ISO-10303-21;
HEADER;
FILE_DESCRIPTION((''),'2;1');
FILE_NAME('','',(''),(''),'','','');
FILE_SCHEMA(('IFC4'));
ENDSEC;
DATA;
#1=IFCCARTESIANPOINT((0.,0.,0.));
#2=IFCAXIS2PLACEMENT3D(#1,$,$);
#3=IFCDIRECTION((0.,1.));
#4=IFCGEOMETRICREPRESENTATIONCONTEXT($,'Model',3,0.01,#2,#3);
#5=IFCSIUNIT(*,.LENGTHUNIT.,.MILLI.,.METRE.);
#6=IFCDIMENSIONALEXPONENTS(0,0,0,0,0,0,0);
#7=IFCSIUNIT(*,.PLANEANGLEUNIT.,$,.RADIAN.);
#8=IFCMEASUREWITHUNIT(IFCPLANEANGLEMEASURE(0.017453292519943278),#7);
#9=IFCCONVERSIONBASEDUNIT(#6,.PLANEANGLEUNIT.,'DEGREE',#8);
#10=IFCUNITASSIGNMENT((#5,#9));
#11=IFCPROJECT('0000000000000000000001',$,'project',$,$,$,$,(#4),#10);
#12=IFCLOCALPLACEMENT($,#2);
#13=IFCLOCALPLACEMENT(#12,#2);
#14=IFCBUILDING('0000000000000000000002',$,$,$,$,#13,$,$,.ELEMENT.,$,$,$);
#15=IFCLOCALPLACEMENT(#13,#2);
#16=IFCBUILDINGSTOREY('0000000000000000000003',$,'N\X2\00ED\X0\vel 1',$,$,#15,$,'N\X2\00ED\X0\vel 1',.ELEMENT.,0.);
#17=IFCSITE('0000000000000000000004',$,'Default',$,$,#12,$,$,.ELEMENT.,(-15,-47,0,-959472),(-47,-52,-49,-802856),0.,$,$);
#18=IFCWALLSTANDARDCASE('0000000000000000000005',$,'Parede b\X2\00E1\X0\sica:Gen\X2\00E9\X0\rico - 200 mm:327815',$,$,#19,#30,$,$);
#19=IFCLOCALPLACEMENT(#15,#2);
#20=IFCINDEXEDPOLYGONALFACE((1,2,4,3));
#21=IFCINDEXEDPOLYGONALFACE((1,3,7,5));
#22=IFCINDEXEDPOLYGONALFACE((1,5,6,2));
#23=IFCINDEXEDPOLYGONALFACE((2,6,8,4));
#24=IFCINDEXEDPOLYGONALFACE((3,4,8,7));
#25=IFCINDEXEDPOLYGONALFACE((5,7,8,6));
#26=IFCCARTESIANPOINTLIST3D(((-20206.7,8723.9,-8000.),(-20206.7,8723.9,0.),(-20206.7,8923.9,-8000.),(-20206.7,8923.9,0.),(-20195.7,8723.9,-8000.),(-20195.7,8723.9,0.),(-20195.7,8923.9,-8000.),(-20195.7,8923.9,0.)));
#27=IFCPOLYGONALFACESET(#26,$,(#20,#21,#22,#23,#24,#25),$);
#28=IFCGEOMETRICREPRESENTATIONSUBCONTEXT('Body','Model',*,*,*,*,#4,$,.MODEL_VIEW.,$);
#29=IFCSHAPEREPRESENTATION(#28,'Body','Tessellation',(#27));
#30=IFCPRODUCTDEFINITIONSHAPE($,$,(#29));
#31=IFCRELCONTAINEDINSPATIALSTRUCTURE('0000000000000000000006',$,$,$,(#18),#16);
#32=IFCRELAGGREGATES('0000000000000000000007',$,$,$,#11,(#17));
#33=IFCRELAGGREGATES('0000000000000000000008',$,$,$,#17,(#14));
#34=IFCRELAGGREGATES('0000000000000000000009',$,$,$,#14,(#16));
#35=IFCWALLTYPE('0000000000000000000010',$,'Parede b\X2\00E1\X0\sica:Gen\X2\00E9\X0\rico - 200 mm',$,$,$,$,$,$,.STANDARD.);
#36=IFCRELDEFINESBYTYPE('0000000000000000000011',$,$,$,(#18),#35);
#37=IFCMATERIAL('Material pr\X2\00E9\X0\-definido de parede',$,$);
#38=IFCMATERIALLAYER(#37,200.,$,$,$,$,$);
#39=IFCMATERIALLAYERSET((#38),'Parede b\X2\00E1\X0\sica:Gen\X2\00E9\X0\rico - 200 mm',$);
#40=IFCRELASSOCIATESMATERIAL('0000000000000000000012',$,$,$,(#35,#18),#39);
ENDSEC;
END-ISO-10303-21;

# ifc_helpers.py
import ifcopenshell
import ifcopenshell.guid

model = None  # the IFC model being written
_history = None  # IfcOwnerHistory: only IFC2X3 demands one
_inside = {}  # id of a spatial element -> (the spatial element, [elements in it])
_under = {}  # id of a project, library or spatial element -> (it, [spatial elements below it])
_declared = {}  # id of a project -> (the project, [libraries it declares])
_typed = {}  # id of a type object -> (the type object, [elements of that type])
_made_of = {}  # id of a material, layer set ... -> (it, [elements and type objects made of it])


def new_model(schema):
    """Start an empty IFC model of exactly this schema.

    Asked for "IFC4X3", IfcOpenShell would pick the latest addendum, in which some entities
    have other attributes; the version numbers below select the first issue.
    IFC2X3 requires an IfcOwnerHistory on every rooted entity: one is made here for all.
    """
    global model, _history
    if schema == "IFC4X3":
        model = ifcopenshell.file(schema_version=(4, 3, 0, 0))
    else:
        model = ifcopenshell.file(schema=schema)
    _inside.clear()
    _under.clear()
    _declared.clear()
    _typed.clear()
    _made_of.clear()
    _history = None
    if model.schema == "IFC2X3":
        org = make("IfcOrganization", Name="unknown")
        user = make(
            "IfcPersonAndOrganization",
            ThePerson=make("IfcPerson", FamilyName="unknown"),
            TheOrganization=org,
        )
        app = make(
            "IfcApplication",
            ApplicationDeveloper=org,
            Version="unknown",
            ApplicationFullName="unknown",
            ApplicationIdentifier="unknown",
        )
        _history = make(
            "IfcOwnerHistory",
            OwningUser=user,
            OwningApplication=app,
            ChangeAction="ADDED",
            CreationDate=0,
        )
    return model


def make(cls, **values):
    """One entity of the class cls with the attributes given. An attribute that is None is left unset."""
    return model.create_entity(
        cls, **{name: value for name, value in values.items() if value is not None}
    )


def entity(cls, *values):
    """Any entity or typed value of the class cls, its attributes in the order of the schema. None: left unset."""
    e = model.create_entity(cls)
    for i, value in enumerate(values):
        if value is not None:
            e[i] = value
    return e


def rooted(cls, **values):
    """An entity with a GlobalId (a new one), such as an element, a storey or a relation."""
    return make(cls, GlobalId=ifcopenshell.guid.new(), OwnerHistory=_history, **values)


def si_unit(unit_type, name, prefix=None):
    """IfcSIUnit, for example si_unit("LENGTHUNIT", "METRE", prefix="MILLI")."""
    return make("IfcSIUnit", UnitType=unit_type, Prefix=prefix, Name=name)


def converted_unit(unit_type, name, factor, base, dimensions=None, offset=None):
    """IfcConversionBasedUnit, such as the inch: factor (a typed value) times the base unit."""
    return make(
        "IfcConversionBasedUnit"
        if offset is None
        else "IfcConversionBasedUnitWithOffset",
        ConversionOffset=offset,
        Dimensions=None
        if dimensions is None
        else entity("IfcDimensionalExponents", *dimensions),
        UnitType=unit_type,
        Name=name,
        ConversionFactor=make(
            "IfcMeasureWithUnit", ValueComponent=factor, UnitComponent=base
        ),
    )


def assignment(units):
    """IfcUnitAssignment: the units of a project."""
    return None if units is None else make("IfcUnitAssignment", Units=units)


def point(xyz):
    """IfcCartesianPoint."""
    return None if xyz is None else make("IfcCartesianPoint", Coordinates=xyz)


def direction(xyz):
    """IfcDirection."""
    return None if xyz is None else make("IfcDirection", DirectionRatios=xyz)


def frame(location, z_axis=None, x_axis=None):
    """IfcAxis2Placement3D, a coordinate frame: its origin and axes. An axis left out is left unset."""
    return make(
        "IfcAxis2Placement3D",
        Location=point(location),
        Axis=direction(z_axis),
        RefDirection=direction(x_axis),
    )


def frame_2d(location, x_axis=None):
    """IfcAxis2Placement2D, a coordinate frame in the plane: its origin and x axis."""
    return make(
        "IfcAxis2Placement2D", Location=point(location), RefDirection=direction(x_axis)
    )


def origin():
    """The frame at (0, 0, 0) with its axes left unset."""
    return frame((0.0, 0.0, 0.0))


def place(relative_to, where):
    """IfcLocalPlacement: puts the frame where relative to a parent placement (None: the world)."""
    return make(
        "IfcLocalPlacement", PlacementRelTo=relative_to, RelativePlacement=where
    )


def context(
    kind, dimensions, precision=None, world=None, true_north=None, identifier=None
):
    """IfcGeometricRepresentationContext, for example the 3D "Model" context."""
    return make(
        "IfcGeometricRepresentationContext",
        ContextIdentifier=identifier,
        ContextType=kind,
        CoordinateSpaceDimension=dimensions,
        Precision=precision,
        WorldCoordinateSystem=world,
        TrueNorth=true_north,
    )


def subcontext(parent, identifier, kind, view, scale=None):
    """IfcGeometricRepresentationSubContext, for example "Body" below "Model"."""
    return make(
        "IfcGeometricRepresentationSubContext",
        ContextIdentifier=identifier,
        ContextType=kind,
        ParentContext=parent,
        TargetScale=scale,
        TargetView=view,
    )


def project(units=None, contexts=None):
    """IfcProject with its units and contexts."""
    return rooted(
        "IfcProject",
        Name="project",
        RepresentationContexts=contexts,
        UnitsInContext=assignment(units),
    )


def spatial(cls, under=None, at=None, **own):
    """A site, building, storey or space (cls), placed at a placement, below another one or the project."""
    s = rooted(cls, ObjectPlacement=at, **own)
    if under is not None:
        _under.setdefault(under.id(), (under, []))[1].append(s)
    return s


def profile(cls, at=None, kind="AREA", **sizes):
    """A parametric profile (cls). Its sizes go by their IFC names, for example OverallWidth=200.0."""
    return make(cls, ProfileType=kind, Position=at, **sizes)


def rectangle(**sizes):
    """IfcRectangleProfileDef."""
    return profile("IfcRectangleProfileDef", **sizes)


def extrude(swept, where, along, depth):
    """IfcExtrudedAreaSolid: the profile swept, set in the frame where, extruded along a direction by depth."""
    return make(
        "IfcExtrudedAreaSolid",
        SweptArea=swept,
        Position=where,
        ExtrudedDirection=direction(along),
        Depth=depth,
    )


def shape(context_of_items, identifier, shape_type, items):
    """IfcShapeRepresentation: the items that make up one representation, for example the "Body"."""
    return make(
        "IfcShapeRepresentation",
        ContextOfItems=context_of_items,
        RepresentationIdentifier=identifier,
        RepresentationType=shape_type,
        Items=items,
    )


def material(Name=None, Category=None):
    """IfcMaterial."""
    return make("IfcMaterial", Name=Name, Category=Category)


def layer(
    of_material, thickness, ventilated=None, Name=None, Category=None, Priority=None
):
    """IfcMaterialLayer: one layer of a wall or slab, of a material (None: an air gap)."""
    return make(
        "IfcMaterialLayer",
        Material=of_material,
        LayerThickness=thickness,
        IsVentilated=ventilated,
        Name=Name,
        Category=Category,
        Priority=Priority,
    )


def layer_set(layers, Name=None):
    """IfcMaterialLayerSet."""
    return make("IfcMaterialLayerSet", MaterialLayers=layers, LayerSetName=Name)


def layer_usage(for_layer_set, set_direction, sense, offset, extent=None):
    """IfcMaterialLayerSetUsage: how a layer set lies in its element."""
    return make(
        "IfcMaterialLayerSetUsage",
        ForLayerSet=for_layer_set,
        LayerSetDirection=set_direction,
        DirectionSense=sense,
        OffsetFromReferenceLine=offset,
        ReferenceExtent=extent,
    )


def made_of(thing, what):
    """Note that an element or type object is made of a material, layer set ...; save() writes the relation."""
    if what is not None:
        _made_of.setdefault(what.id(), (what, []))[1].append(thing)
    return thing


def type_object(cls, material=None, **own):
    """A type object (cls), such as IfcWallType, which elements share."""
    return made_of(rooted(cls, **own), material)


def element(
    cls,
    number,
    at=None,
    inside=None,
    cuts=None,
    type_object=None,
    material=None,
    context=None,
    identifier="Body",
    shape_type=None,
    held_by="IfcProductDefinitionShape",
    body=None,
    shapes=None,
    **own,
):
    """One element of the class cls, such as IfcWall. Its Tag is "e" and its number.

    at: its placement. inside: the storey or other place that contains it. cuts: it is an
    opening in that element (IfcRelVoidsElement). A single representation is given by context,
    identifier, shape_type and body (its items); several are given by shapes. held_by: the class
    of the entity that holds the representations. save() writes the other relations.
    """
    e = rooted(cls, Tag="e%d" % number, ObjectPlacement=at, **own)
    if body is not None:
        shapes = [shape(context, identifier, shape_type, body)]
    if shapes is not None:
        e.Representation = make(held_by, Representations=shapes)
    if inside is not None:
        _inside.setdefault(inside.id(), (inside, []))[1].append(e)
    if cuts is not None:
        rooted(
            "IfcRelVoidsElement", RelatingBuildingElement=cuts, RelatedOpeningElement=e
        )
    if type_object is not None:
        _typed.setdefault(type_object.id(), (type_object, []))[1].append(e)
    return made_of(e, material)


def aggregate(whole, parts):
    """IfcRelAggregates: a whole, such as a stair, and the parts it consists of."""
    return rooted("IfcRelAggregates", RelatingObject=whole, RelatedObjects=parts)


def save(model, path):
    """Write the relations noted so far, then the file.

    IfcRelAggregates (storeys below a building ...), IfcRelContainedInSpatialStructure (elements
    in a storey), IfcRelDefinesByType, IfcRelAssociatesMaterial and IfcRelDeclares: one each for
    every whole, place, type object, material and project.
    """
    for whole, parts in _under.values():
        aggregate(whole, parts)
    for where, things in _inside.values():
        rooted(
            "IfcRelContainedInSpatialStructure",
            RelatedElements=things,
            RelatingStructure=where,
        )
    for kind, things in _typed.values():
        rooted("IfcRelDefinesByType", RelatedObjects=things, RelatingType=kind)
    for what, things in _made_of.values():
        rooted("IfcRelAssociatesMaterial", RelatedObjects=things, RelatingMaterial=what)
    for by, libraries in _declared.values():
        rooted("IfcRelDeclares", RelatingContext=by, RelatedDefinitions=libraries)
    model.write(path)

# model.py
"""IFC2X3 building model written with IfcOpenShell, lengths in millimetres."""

from ifc_helpers import new_model, entity, si_unit, converted_unit, direction, frame, frame_2d, origin, place, context, subcontext, project, spatial, rectangle, extrude, material, layer, layer_set, layer_usage, type_object, element, save


model = new_model("IFC2X3")

# Units and contexts
model_context = context("Model", 3, precision=0.01, world=origin(), true_north=direction((0.0, 1.0)))
body_context = subcontext(model_context, "Body", "Model", "MODEL_VIEW")
ifc_project = project(units=[si_unit("LENGTHUNIT", "METRE", prefix="MILLI"), converted_unit("PLANEANGLEUNIT", "DEGREE", entity("IfcPlaneAngleMeasure", 0.017453292519943278), si_unit("PLANEANGLEUNIT", "RADIAN"), dimensions=[0, 0, 0, 0, 0, 0, 0])], contexts=[model_context])

# Site, building, storey
site_placement = place(None, origin())
site = spatial("IfcSite", under=ifc_project, at=site_placement, Name="Default", CompositionType="ELEMENT", RefLatitude=(-15, -47, 0, -959472), RefLongitude=(-47, -52, -49, -802856), RefElevation=0.0)
building_placement = place(site_placement, origin())
building = spatial("IfcBuilding", under=site, at=building_placement, CompositionType="ELEMENT")
storey_placement = place(building_placement, origin())
storey = spatial("IfcBuildingStorey", under=building, at=storey_placement, Name="Nível 1", LongName="Nível 1", CompositionType="ELEMENT", Elevation=0.0)

# Wall
ifc_material_1 = material(Name="Material pré-definido de parede")
ifc_layer = layer(ifc_material_1, 200.0)
ifc_layer_set = layer_set([ifc_layer], Name="Parede básica:Genérico - 200 mm")
ifc_layer_usage = layer_usage(ifc_layer_set, "AXIS2", "NEGATIVE", 100.0)
wall_type = type_object("IfcWallType", Name="Parede básica:Genérico - 200 mm", PredefinedType="STANDARD", material=ifc_layer_set)
wall_placement = place(storey_placement, frame((-20195.7, 8823.9, -8000.0), z_axis=(0.0, 0.0, 1.0), x_axis=(-1.0, 0.0, 0.0)))
element("IfcWallStandardCase", 1, at=wall_placement, inside=storey, type_object=wall_type, material=ifc_layer_usage, Name="Parede básica:Genérico - 200 mm:327815", context=body_context, shape_type="SweptSolid", body=[
    extrude(rectangle(XDim=11.0, YDim=200.0, at=frame_2d((5.5, 0.0), x_axis=(-1.0, 0.0))), origin(), (0.0, 0.0, 1.0), 8000.0),
])

save(model, "model.ifc")
